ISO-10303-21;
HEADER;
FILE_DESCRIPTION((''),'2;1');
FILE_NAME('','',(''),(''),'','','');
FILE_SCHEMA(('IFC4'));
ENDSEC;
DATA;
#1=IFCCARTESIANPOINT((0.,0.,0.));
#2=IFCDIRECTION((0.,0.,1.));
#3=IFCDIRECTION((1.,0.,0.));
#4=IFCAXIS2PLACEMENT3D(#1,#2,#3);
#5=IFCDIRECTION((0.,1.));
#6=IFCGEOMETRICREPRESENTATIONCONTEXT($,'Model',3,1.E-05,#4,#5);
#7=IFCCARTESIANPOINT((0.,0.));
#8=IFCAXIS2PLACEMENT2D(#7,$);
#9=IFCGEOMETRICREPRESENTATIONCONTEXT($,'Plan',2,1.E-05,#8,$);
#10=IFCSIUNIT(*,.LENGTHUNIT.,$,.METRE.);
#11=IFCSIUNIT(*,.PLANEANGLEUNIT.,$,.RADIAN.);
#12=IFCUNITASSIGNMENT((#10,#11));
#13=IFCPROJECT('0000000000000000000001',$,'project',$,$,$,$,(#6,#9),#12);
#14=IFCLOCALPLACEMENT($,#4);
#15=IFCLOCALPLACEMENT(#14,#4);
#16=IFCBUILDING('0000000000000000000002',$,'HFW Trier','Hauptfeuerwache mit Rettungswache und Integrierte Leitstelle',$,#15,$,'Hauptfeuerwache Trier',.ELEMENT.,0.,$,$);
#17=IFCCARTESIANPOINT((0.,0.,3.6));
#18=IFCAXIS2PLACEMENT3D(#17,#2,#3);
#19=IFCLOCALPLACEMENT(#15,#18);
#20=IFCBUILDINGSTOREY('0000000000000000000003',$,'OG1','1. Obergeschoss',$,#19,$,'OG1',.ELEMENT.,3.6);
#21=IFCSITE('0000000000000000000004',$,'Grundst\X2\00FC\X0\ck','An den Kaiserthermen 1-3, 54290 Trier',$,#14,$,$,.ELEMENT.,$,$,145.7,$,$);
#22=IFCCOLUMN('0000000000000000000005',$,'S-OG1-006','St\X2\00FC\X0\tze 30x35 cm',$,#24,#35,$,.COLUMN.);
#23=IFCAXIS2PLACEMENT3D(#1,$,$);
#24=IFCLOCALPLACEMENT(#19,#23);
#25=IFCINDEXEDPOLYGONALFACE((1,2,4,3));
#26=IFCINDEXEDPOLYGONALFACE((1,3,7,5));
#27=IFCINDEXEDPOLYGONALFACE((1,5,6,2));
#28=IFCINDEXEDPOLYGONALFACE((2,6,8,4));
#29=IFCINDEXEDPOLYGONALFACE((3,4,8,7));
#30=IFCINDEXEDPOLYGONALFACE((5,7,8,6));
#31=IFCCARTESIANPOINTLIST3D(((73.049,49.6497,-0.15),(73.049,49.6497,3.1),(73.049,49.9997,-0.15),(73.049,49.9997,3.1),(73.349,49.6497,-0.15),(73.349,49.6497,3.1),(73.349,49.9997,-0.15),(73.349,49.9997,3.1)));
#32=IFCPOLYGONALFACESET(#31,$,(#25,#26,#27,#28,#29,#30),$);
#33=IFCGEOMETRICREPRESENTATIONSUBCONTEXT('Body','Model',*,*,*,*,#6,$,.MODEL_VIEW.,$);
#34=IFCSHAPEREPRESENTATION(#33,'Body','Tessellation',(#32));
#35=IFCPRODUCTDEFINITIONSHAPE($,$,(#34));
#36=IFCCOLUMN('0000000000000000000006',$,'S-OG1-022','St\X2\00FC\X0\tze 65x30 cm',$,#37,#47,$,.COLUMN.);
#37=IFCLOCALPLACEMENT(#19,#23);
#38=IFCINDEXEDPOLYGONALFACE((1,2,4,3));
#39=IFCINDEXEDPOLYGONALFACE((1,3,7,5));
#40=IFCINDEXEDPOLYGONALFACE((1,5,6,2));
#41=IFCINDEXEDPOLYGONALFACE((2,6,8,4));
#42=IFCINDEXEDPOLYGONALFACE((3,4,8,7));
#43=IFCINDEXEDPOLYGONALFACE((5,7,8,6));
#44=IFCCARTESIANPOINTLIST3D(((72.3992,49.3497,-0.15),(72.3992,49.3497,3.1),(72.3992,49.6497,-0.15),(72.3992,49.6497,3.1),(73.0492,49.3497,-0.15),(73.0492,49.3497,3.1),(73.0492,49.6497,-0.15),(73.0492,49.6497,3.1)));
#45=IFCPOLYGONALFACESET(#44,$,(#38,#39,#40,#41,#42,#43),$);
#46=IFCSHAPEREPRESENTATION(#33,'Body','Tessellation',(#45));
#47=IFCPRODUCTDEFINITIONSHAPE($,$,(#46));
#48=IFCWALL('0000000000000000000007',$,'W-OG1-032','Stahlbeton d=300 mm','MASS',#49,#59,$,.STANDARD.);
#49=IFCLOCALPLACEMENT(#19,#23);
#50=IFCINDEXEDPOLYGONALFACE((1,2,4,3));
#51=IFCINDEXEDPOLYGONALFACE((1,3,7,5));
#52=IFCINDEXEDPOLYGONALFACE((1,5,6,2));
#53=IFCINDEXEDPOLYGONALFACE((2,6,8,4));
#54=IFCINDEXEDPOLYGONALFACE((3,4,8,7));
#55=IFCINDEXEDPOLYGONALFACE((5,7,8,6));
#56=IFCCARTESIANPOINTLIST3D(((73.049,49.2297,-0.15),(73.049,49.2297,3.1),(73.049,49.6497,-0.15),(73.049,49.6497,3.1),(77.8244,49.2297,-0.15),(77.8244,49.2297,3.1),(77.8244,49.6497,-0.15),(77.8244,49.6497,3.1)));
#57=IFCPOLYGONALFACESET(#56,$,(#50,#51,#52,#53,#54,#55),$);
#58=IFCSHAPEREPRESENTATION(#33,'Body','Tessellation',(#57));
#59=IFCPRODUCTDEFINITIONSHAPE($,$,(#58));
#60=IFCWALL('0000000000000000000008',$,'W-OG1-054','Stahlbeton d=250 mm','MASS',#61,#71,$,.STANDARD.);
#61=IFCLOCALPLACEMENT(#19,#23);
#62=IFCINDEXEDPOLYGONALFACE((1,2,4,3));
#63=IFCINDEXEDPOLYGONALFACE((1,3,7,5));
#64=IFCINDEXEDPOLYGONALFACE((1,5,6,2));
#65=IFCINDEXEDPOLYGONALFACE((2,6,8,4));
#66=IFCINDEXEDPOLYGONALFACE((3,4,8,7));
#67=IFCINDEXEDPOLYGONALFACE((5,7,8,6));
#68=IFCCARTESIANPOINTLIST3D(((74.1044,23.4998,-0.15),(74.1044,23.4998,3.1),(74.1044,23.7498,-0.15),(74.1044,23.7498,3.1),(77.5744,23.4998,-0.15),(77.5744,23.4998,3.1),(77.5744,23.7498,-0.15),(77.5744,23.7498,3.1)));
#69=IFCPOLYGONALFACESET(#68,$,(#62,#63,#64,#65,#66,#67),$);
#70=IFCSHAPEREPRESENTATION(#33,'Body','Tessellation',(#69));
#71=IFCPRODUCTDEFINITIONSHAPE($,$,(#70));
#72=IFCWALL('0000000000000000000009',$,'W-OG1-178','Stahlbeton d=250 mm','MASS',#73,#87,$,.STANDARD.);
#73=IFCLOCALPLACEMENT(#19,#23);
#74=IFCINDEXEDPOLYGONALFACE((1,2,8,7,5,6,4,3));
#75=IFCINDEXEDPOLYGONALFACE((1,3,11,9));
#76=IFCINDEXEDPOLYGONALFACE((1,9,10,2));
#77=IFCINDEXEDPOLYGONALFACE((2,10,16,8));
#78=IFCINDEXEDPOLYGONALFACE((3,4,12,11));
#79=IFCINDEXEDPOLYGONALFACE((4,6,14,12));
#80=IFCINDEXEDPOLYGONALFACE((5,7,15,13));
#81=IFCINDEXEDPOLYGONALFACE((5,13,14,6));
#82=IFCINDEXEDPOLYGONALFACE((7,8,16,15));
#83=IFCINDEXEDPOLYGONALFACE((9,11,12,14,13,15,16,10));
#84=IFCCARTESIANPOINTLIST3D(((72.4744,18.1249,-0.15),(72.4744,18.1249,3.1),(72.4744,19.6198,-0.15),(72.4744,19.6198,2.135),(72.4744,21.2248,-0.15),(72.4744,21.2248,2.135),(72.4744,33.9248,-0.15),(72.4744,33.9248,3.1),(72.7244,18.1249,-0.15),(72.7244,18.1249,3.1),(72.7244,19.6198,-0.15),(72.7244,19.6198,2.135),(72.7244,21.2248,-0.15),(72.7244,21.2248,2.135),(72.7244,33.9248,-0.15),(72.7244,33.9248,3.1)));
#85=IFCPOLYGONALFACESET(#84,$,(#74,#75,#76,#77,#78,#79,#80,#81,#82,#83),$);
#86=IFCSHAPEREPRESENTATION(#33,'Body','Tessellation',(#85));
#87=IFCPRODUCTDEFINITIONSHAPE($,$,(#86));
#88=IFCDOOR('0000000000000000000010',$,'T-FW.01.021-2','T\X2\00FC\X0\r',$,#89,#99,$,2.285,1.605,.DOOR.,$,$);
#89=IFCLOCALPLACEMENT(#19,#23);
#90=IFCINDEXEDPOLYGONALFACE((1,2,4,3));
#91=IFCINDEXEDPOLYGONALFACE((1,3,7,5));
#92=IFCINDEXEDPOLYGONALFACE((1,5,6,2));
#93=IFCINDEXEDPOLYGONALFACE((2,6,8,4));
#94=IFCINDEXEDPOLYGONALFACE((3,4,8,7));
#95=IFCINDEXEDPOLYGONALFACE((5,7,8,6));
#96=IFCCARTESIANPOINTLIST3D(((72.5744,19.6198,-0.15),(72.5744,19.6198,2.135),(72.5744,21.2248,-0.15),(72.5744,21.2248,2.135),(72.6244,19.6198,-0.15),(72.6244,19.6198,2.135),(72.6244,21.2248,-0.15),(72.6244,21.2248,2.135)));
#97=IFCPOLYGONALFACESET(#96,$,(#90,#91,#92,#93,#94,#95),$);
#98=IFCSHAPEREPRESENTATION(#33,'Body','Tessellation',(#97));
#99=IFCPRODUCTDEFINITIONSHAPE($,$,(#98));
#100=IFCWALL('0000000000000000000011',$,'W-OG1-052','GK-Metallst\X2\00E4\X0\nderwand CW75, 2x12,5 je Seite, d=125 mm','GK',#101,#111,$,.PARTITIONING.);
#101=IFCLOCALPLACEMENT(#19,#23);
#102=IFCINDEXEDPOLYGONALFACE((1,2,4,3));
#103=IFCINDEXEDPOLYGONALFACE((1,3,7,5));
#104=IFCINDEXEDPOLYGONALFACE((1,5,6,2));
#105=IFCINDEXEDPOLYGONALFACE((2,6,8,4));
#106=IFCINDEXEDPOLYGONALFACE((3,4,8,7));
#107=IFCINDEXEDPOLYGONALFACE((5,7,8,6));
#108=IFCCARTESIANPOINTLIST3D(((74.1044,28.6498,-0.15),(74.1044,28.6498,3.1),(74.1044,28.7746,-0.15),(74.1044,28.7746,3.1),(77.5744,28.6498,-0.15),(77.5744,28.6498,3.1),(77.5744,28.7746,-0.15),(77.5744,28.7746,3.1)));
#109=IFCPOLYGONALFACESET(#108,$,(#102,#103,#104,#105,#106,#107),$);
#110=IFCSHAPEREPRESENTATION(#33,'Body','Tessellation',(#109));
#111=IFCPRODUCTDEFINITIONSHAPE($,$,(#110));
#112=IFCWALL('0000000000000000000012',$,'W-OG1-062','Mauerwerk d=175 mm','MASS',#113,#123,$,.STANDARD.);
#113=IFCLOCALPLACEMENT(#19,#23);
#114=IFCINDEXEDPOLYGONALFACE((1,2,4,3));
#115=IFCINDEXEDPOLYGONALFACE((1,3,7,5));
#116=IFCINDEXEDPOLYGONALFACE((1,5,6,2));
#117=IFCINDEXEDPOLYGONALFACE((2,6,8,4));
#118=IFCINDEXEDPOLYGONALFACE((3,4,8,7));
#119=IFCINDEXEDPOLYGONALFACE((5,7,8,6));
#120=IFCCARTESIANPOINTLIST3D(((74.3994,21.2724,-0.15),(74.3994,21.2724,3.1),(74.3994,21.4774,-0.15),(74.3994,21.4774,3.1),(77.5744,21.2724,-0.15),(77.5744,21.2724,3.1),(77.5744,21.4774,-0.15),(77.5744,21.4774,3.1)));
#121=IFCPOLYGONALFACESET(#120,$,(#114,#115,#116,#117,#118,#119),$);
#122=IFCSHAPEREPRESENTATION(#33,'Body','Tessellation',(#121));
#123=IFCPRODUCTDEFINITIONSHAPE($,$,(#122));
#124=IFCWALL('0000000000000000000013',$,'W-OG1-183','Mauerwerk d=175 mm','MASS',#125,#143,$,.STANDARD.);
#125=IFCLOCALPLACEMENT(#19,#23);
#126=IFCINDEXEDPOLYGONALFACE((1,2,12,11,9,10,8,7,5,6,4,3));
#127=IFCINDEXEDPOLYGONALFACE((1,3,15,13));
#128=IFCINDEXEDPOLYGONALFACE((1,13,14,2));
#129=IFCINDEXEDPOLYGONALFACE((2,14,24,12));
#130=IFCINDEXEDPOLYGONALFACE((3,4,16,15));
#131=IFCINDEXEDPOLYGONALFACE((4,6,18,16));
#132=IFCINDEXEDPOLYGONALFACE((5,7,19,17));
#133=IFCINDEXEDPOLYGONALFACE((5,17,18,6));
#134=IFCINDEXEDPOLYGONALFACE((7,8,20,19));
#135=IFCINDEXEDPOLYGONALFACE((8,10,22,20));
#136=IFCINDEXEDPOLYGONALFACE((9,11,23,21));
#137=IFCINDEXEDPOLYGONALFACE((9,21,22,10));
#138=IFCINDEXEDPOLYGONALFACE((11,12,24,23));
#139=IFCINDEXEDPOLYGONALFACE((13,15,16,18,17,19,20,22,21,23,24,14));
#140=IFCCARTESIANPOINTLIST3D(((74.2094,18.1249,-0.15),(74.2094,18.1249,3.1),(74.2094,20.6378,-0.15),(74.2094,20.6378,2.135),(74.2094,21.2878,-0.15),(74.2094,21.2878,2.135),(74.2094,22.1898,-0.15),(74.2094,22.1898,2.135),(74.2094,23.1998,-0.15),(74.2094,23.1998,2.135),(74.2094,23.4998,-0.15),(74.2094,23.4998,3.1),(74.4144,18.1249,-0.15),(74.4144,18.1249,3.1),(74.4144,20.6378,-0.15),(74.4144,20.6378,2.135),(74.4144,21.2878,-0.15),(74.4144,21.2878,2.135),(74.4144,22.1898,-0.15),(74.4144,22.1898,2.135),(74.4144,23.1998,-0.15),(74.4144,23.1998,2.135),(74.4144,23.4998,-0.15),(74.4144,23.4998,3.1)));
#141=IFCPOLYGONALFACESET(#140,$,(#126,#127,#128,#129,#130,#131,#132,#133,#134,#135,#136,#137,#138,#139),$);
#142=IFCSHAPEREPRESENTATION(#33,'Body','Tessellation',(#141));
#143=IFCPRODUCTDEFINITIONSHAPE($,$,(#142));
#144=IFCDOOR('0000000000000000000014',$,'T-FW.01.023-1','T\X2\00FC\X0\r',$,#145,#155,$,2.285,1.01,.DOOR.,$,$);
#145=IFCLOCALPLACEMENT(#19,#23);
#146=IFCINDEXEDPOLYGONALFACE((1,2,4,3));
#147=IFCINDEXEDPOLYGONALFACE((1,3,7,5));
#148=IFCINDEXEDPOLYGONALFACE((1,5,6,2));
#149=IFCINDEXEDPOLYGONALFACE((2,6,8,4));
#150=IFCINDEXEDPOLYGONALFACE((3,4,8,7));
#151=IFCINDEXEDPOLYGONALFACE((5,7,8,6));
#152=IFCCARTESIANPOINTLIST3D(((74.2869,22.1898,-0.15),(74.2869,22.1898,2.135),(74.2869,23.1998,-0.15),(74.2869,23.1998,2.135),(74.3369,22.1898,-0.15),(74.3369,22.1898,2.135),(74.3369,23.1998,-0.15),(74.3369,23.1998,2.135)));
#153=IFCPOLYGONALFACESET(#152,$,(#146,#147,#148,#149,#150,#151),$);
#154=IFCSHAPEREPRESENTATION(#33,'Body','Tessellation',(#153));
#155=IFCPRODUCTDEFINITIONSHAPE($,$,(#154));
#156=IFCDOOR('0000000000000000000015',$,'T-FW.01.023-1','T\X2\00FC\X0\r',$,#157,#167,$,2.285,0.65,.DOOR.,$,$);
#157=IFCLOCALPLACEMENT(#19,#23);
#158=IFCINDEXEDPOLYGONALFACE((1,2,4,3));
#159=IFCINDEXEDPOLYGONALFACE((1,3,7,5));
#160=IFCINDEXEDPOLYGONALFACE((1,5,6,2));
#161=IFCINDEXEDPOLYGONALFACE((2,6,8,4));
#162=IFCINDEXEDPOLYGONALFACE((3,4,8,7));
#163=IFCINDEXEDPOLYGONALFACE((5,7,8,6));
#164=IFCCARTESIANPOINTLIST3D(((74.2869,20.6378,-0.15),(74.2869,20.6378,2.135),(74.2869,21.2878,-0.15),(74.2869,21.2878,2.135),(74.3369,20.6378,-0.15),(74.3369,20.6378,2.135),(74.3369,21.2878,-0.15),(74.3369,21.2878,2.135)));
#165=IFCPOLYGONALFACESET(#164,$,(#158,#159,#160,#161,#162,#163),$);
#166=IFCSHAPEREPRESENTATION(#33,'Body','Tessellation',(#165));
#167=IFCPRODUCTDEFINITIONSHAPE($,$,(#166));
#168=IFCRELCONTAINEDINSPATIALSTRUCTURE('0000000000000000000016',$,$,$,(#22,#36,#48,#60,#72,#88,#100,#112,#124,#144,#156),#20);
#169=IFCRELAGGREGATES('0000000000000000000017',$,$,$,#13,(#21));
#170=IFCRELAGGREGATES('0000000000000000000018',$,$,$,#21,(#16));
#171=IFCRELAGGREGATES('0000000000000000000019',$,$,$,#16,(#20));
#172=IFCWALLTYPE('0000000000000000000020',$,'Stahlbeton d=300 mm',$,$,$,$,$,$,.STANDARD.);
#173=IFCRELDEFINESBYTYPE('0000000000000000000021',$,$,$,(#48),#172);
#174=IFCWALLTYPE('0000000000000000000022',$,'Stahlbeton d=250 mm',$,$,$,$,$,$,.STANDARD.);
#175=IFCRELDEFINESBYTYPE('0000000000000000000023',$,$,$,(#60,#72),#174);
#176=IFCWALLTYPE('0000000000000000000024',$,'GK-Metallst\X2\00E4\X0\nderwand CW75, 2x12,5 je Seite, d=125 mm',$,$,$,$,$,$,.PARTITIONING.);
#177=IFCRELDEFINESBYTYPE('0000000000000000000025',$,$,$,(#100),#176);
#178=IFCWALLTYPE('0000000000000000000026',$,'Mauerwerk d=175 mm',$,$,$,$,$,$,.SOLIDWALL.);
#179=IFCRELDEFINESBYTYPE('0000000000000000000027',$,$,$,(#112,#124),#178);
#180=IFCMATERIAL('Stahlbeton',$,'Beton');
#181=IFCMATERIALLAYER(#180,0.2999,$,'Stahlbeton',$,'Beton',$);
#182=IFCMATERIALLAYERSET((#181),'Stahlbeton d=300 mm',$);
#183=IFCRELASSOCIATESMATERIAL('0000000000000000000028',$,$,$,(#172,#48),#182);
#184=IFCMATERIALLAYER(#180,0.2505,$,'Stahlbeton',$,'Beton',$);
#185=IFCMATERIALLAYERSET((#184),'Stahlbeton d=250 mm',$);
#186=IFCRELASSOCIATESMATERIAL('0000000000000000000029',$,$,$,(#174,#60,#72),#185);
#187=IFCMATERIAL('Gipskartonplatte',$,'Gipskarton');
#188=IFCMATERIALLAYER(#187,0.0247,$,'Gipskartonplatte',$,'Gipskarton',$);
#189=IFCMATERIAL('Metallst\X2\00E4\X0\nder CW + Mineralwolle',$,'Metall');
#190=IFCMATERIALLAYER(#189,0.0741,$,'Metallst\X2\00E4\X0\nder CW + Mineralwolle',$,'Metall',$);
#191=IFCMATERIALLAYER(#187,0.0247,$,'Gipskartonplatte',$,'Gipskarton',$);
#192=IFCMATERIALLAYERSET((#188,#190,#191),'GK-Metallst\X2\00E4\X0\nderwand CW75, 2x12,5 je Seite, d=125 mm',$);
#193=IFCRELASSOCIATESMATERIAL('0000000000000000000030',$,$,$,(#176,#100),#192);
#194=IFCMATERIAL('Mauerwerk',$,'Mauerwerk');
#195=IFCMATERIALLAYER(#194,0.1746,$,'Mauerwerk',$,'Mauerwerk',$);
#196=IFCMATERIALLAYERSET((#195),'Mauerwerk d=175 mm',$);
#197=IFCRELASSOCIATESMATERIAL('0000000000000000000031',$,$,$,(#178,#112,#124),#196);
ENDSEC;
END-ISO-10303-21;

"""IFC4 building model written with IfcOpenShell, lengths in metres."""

from ifc_helpers import new_model, si_unit, direction, frame, frame_2d, origin_with_axes, origin_2d, place, context, subcontext, project, spatial, rectangle, extrude, material, layer, layer_set, layer_usage, type_object, element, fill, save


model = new_model("IFC4")

# Units and contexts
model_context = context("Model", 3, precision=1e-05, world=origin_with_axes(), true_north=direction((0.0, 1.0)))
plan_context = context("Plan", 2, precision=1e-05, world=origin_2d())
body_context = subcontext(model_context, "Body", "Model", "MODEL_VIEW")
ifc_project = project(units=[si_unit("LENGTHUNIT", "METRE"), si_unit("PLANEANGLEUNIT", "RADIAN")], contexts=[model_context, plan_context])

# Site, building, storey
site_placement = place(None, origin_with_axes())
site = spatial("IfcSite", under=ifc_project, at=site_placement, Name="Grundstück", Description="An den Kaiserthermen 1-3, 54290 Trier", CompositionType="ELEMENT", RefElevation=145.7)
building_placement = place(site_placement, origin_with_axes())
building = spatial("IfcBuilding", under=site, at=building_placement, Name="HFW Trier", Description="Hauptfeuerwache mit Rettungswache und Integrierte Leitstelle", LongName="Hauptfeuerwache Trier", CompositionType="ELEMENT", ElevationOfRefHeight=0.0)
storey_placement = place(building_placement, frame((0.0, 0.0, 3.6), z_axis=(0.0, 0.0, 1.0), x_axis=(1.0, 0.0, 0.0)))
storey = spatial("IfcBuildingStorey", under=building, at=storey_placement, Name="OG1", Description="1. Obergeschoss", LongName="OG1", CompositionType="ELEMENT", Elevation=3.6)

# Columns
column_1_placement = place(storey_placement, frame((73.049, 49.8247, -0.15), z_axis=(0.0, 0.0, 1.0), x_axis=(1.0, 0.0, 0.0)))
element("IfcColumn", 1, at=column_1_placement, inside=storey, Name="S-OG1-006", Description="Stütze 30x35 cm", PredefinedType="COLUMN", context=body_context, shape_type="SweptSolid", body=[
    extrude(rectangle(XDim=0.3, YDim=0.35, at=frame_2d((0.15, 0.0))), origin_with_axes(), (0.0, 0.0, 1.0), 3.25),
])
column_2_placement = place(storey_placement, frame((72.3992, 49.4997, -0.15), z_axis=(0.0, 0.0, 1.0), x_axis=(1.0, 0.0, 0.0)))
element("IfcColumn", 2, at=column_2_placement, inside=storey, Name="S-OG1-022", Description="Stütze 65x30 cm", PredefinedType="COLUMN", context=body_context, shape_type="SweptSolid", body=[
    extrude(rectangle(XDim=0.65, YDim=0.3, at=frame_2d((0.325, 0.0))), origin_with_axes(), (0.0, 0.0, 1.0), 3.25),
])

# Walls
ifc_material_1 = material(Name="Stahlbeton", Category="Beton")
ifc_layer_1 = layer(ifc_material_1, 0.2999, Name="Stahlbeton", Category="Beton")
ifc_layer_set_1 = layer_set([ifc_layer_1], Name="Stahlbeton d=300 mm")
ifc_layer_usage_1 = layer_usage(ifc_layer_set_1, "AXIS2", "POSITIVE", -0.21)
wall_type_1 = type_object("IfcWallType", Name="Stahlbeton d=300 mm", PredefinedType="STANDARD", material=ifc_layer_set_1)
wall_1_placement = place(storey_placement, frame((73.049, 49.4397, -0.15), z_axis=(0.0, 0.0, 1.0), x_axis=(1.0, 0.0, 0.0)))
element("IfcWall", 3, at=wall_1_placement, inside=storey, type_object=wall_type_1, material=ifc_layer_usage_1, Name="W-OG1-032", Description="Stahlbeton d=300 mm", ObjectType="MASS", PredefinedType="STANDARD", context=body_context, shape_type="SweptSolid", body=[
    extrude(rectangle(XDim=4.7754, YDim=0.42, at=frame_2d((2.3877, 0.0))), origin_with_axes(), (0.0, 0.0, 1.0), 3.25),
])
ifc_layer_2 = layer(ifc_material_1, 0.2505, Name="Stahlbeton", Category="Beton")
ifc_layer_set_2 = layer_set([ifc_layer_2], Name="Stahlbeton d=250 mm")
ifc_layer_usage_2 = layer_usage(ifc_layer_set_2, "AXIS2", "POSITIVE", -0.125)
wall_type_2 = type_object("IfcWallType", Name="Stahlbeton d=250 mm", PredefinedType="STANDARD", material=ifc_layer_set_2)
wall_2_placement = place(storey_placement, frame((74.1044, 23.6248, -0.15), z_axis=(0.0, 0.0, 1.0), x_axis=(1.0, 0.0, 0.0)))
element("IfcWall", 4, at=wall_2_placement, inside=storey, type_object=wall_type_2, material=ifc_layer_usage_2, Name="W-OG1-054", Description="Stahlbeton d=250 mm", ObjectType="MASS", PredefinedType="STANDARD", context=body_context, shape_type="SweptSolid", body=[
    extrude(rectangle(XDim=3.47, YDim=0.25, at=frame_2d((1.735, 0.0))), origin_with_axes(), (0.0, 0.0, 1.0), 3.25),
])

# Wall, opening, door
ifc_layer_usage_3 = layer_usage(ifc_layer_set_2, "AXIS2", "POSITIVE", -0.125)
wall_3_placement = place(storey_placement, frame((72.5994, 33.9248, -0.15), z_axis=(0.0, 0.0, 1.0), x_axis=(0.0, -1.0, 0.0)))
wall_3 = element("IfcWall", 5, at=wall_3_placement, inside=storey, type_object=wall_type_2, material=ifc_layer_usage_3, Name="W-OG1-178", Description="Stahlbeton d=250 mm", ObjectType="MASS", PredefinedType="STANDARD", context=body_context, shape_type="SweptSolid", body=[
    extrude(rectangle(XDim=15.7999, YDim=0.25, at=frame_2d((7.8999, 0.0))), origin_with_axes(), (0.0, 0.0, 1.0), 3.25),
])
opening_1_placement = place(wall_3_placement, frame((12.7, 0.0, 0.0), z_axis=(0.0, 0.0, 1.0), x_axis=(1.0, 0.0, 0.0)))
opening_1 = element("IfcOpeningElement", 6, at=opening_1_placement, cuts=wall_3, PredefinedType="OPENING", context=body_context, shape_type="SweptSolid", body=[
    extrude(rectangle(XDim=1.605, YDim=0.35, at=frame_2d((0.8025, 0.0))), origin_with_axes(), (0.0, 0.0, 1.0), 2.285),
])
door_1_placement = place(wall_3_placement, frame((12.7, 0.0, 0.0), z_axis=(0.0, 0.0, 1.0), x_axis=(1.0, 0.0, 0.0)))
door_1 = element("IfcDoor", 7, at=door_1_placement, inside=storey, Name="T-FW.01.021-2", Description="Tür", OverallHeight=2.285, OverallWidth=1.605, PredefinedType="DOOR", context=body_context, shape_type="SweptSolid", body=[
    extrude(rectangle(XDim=1.605, YDim=0.05, at=frame_2d((0.8025, 0.0))), origin_with_axes(), (0.0, 0.0, 1.0), 2.285),
])
fill(opening_1, door_1)

# Walls
ifc_material_2 = material(Name="Gipskartonplatte", Category="Gipskarton")
ifc_layer_3 = layer(ifc_material_2, 0.0247, Name="Gipskartonplatte", Category="Gipskarton")
ifc_material_3 = material(Name="Metallständer CW + Mineralwolle", Category="Metall")
ifc_layer_4 = layer(ifc_material_3, 0.0741, Name="Metallständer CW + Mineralwolle", Category="Metall")
ifc_layer_5 = layer(ifc_material_2, 0.0247, Name="Gipskartonplatte", Category="Gipskarton")
ifc_layer_set_3 = layer_set([ifc_layer_3, ifc_layer_4, ifc_layer_5], Name="GK-Metallständerwand CW75, 2x12,5 je Seite, d=125 mm")
ifc_layer_usage_4 = layer_usage(ifc_layer_set_3, "AXIS2", "POSITIVE", -0.0624)
wall_type_3 = type_object("IfcWallType", Name="GK-Metallständerwand CW75, 2x12,5 je Seite, d=125 mm", PredefinedType="PARTITIONING", material=ifc_layer_set_3)
wall_4_placement = place(storey_placement, frame((74.1044, 28.7122, -0.15), z_axis=(0.0, 0.0, 1.0), x_axis=(1.0, 0.0, 0.0)))
element("IfcWall", 8, at=wall_4_placement, inside=storey, type_object=wall_type_3, material=ifc_layer_usage_4, Name="W-OG1-052", Description="GK-Metallständerwand CW75, 2x12,5 je Seite, d=125 mm", ObjectType="GK", PredefinedType="PARTITIONING", context=body_context, shape_type="SweptSolid", body=[
    extrude(rectangle(XDim=3.47, YDim=0.1249, at=frame_2d((1.735, 0.0))), origin_with_axes(), (0.0, 0.0, 1.0), 3.25),
])
ifc_material_4 = material(Name="Mauerwerk", Category="Mauerwerk")
ifc_layer_6 = layer(ifc_material_4, 0.1746, Name="Mauerwerk", Category="Mauerwerk")
ifc_layer_set_4 = layer_set([ifc_layer_6], Name="Mauerwerk d=175 mm")
ifc_layer_usage_5 = layer_usage(ifc_layer_set_4, "AXIS2", "POSITIVE", -0.1025)
wall_type_4 = type_object("IfcWallType", Name="Mauerwerk d=175 mm", PredefinedType="SOLIDWALL", material=ifc_layer_set_4)
wall_5_placement = place(storey_placement, frame((74.3994, 21.3749, -0.15), z_axis=(0.0, 0.0, 1.0), x_axis=(1.0, 0.0, 0.0)))
element("IfcWall", 9, at=wall_5_placement, inside=storey, type_object=wall_type_4, material=ifc_layer_usage_5, Name="W-OG1-062", Description="Mauerwerk d=175 mm", ObjectType="MASS", PredefinedType="STANDARD", context=body_context, shape_type="SweptSolid", body=[
    extrude(rectangle(XDim=3.175, YDim=0.205, at=frame_2d((1.5875, 0.0))), origin_with_axes(), (0.0, 0.0, 1.0), 3.25),
])

# Wall, openings, doors
ifc_layer_usage_6 = layer_usage(ifc_layer_set_4, "AXIS2", "POSITIVE", -0.1025)
wall_6_placement = place(storey_placement, frame((74.3119, 23.4998, -0.15), z_axis=(0.0, 0.0, 1.0), x_axis=(0.0, -1.0, 0.0)))
wall_6 = element("IfcWall", 10, at=wall_6_placement, inside=storey, type_object=wall_type_4, material=ifc_layer_usage_6, Name="W-OG1-183", Description="Mauerwerk d=175 mm", ObjectType="MASS", PredefinedType="STANDARD", context=body_context, shape_type="SweptSolid", body=[
    extrude(rectangle(XDim=5.3749, YDim=0.205, at=frame_2d((2.6875, 0.0))), origin_with_axes(), (0.0, 0.0, 1.0), 3.25),
])
opening_2_placement = place(wall_6_placement, frame((0.3, 0.0, 0.0), z_axis=(0.0, 0.0, 1.0), x_axis=(1.0, 0.0, 0.0)))
opening_2 = element("IfcOpeningElement", 11, at=opening_2_placement, cuts=wall_6, PredefinedType="OPENING", context=body_context, shape_type="SweptSolid", body=[
    extrude(rectangle(XDim=1.01, YDim=0.305, at=frame_2d((0.505, 0.0))), origin_with_axes(), (0.0, 0.0, 1.0), 2.285),
])
opening_3_placement = place(wall_6_placement, frame((2.212, 0.0, 0.0), z_axis=(0.0, 0.0, 1.0), x_axis=(1.0, 0.0, 0.0)))
opening_3 = element("IfcOpeningElement", 12, at=opening_3_placement, cuts=wall_6, PredefinedType="OPENING", context=body_context, shape_type="SweptSolid", body=[
    extrude(rectangle(XDim=0.65, YDim=0.305, at=frame_2d((0.325, 0.0))), origin_with_axes(), (0.0, 0.0, 1.0), 2.285),
])
door_2_placement = place(wall_6_placement, frame((0.3, 0.0, 0.0), z_axis=(0.0, 0.0, 1.0), x_axis=(1.0, 0.0, 0.0)))
door_2 = element("IfcDoor", 13, at=door_2_placement, inside=storey, Name="T-FW.01.023-1", Description="Tür", OverallHeight=2.285, OverallWidth=1.01, PredefinedType="DOOR", context=body_context, shape_type="SweptSolid", body=[
    extrude(rectangle(XDim=1.01, YDim=0.05, at=frame_2d((0.505, 0.0))), origin_with_axes(), (0.0, 0.0, 1.0), 2.285),
])
fill(opening_2, door_2)
door_3_placement = place(wall_6_placement, frame((2.212, 0.0, 0.0), z_axis=(0.0, 0.0, 1.0), x_axis=(1.0, 0.0, 0.0)))
door_3 = element("IfcDoor", 14, at=door_3_placement, inside=storey, Name="T-FW.01.023-1", Description="Tür", OverallHeight=2.285, OverallWidth=0.65, PredefinedType="DOOR", context=body_context, shape_type="SweptSolid", body=[
    extrude(rectangle(XDim=0.65, YDim=0.05, at=frame_2d((0.325, 0.0))), origin_with_axes(), (0.0, 0.0, 1.0), 2.285),
])
fill(opening_3, door_3)

save(model, "model.ifc")
